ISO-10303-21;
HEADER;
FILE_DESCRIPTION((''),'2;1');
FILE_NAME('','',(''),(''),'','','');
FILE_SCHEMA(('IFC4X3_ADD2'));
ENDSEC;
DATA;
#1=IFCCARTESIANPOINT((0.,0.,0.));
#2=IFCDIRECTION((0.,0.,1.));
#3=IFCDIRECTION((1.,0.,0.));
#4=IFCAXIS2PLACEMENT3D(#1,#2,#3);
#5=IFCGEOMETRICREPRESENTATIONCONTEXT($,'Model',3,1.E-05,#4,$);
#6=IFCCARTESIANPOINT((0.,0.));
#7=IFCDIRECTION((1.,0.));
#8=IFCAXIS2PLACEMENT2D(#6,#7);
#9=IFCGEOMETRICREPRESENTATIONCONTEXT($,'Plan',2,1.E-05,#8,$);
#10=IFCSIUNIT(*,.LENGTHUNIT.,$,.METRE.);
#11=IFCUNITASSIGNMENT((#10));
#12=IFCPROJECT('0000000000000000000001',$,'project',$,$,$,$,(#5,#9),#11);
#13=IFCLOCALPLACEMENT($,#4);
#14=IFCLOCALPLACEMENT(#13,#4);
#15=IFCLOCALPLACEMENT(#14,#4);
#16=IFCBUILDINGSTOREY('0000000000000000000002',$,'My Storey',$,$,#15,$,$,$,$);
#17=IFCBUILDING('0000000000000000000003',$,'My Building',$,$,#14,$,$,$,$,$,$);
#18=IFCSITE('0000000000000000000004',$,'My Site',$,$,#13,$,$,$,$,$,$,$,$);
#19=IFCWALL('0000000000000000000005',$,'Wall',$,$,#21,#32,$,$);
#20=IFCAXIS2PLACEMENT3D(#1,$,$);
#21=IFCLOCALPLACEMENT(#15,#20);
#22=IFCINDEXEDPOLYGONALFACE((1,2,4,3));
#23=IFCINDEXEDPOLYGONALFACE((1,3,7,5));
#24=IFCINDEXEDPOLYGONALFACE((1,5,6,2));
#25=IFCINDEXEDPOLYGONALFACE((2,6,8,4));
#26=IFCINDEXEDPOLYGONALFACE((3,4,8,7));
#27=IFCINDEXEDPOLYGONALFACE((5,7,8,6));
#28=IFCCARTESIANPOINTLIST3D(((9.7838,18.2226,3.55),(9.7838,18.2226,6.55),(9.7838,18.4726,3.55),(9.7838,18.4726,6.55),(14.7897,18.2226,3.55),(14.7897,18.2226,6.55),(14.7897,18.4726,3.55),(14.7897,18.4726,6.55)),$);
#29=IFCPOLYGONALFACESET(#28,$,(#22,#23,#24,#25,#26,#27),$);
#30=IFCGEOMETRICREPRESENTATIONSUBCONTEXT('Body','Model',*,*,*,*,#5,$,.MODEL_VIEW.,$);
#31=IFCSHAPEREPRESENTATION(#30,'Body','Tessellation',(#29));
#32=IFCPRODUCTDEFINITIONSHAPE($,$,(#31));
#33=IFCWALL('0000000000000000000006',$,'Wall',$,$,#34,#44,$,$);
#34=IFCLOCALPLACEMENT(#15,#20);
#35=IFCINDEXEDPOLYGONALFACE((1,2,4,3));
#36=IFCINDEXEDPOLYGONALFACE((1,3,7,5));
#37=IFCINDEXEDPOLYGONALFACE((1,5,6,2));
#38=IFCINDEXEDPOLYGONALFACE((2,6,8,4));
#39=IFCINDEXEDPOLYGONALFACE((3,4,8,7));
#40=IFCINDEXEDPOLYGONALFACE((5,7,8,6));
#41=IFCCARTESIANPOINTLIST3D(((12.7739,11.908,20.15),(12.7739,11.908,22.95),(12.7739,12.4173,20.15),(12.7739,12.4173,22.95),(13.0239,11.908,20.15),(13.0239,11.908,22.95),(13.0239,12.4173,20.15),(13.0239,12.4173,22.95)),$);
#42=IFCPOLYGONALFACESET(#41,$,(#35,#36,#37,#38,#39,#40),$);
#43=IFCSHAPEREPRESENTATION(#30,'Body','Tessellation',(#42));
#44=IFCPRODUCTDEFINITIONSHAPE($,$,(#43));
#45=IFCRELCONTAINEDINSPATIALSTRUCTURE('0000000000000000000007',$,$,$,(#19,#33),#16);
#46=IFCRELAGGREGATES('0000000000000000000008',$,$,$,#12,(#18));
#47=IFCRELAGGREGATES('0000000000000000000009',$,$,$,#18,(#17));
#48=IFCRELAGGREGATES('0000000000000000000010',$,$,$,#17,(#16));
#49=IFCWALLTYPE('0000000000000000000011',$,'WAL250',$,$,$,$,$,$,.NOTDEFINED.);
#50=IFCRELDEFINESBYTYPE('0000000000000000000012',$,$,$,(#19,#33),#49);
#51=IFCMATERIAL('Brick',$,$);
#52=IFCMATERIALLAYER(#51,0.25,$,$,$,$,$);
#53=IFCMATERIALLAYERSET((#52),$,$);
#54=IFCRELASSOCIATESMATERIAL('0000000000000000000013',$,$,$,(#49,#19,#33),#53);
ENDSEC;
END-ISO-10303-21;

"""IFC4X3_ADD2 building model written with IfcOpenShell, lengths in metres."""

from ifc_helpers import new_model, si_unit, frame, origin_with_axes, origin_2d_with_axis, place, context, subcontext, project, spatial, line, indexed_curve, outline, extrude, material, layer, layer_set, layer_usage, type_object, element, save


model = new_model("IFC4X3_ADD2")

# Units and contexts
model_context = context("Model", 3, precision=1e-05, world=origin_with_axes())
plan_context = context("Plan", 2, precision=1e-05, world=origin_2d_with_axis())
body_context = subcontext(model_context, "Body", "Model", "MODEL_VIEW")
ifc_project = project(units=[si_unit("LENGTHUNIT", "METRE")], contexts=[model_context, plan_context])

# Site, building, storey
site_placement = place(None, origin_with_axes())
site = spatial("IfcSite", under=ifc_project, at=site_placement, Name="My Site")
building_placement = place(site_placement, origin_with_axes())
building = spatial("IfcBuilding", under=site, at=building_placement, Name="My Building")
storey_placement = place(building_placement, origin_with_axes())
storey = spatial("IfcBuildingStorey", under=building, at=storey_placement, Name="My Storey")

# Shared definitions
ifc_material_1 = material(Name="Brick")

# Walls
ifc_layer_1 = layer(ifc_material_1, 0.25)
ifc_layer_set_1 = layer_set([ifc_layer_1])
wall_type = type_object("IfcWallType", Name="WAL250", PredefinedType="NOTDEFINED", material=ifc_layer_set_1)
ifc_layer_usage_1 = layer_usage(ifc_layer_set_1, "AXIS2", "POSITIVE", 0.0)
wall_1_placement = place(storey_placement, frame((9.7838, 18.2226, 3.55), z_axis=(0.0, 0.0, 1.0), x_axis=(1.0, 0.000006, 0.0)))
element("IfcWall", 1, at=wall_1_placement, inside=storey, type_object=wall_type, material=ifc_layer_usage_1, Name="Wall", context=body_context, shape_type="SweptSolid", body=[
    extrude(outline(indexed_curve([(0.0, 0.0), (0.0, 0.25), (5.0059, 0.25), (5.0059, 0.0)], segments=[line(1, 2, 3, 4, 1)])), origin_with_axes(), (0.0, 0.0, 1.0), 3.0),
])
ifc_layer_usage_2 = layer_usage(ifc_layer_set_1, "AXIS2", "NEGATIVE", 0.0)
wall_2_placement = place(storey_placement, frame((12.7739, 11.908, 20.15), z_axis=(0.0, 0.0, 1.0), x_axis=(-0.000005, 1.0, 0.0)))
element("IfcWall", 2, at=wall_2_placement, inside=storey, type_object=wall_type, material=ifc_layer_usage_2, Name="Wall", context=body_context, shape_type="SweptSolid", body=[
    extrude(outline(indexed_curve([(0.0, -0.25), (0.0, 0.0), (0.5093, 0.0), (0.5093, -0.25)], segments=[line(1, 2, 3, 4, 1)])), origin_with_axes(), (0.0, 0.0, 1.0), 2.8),
])

save(model, "model.ifc")
